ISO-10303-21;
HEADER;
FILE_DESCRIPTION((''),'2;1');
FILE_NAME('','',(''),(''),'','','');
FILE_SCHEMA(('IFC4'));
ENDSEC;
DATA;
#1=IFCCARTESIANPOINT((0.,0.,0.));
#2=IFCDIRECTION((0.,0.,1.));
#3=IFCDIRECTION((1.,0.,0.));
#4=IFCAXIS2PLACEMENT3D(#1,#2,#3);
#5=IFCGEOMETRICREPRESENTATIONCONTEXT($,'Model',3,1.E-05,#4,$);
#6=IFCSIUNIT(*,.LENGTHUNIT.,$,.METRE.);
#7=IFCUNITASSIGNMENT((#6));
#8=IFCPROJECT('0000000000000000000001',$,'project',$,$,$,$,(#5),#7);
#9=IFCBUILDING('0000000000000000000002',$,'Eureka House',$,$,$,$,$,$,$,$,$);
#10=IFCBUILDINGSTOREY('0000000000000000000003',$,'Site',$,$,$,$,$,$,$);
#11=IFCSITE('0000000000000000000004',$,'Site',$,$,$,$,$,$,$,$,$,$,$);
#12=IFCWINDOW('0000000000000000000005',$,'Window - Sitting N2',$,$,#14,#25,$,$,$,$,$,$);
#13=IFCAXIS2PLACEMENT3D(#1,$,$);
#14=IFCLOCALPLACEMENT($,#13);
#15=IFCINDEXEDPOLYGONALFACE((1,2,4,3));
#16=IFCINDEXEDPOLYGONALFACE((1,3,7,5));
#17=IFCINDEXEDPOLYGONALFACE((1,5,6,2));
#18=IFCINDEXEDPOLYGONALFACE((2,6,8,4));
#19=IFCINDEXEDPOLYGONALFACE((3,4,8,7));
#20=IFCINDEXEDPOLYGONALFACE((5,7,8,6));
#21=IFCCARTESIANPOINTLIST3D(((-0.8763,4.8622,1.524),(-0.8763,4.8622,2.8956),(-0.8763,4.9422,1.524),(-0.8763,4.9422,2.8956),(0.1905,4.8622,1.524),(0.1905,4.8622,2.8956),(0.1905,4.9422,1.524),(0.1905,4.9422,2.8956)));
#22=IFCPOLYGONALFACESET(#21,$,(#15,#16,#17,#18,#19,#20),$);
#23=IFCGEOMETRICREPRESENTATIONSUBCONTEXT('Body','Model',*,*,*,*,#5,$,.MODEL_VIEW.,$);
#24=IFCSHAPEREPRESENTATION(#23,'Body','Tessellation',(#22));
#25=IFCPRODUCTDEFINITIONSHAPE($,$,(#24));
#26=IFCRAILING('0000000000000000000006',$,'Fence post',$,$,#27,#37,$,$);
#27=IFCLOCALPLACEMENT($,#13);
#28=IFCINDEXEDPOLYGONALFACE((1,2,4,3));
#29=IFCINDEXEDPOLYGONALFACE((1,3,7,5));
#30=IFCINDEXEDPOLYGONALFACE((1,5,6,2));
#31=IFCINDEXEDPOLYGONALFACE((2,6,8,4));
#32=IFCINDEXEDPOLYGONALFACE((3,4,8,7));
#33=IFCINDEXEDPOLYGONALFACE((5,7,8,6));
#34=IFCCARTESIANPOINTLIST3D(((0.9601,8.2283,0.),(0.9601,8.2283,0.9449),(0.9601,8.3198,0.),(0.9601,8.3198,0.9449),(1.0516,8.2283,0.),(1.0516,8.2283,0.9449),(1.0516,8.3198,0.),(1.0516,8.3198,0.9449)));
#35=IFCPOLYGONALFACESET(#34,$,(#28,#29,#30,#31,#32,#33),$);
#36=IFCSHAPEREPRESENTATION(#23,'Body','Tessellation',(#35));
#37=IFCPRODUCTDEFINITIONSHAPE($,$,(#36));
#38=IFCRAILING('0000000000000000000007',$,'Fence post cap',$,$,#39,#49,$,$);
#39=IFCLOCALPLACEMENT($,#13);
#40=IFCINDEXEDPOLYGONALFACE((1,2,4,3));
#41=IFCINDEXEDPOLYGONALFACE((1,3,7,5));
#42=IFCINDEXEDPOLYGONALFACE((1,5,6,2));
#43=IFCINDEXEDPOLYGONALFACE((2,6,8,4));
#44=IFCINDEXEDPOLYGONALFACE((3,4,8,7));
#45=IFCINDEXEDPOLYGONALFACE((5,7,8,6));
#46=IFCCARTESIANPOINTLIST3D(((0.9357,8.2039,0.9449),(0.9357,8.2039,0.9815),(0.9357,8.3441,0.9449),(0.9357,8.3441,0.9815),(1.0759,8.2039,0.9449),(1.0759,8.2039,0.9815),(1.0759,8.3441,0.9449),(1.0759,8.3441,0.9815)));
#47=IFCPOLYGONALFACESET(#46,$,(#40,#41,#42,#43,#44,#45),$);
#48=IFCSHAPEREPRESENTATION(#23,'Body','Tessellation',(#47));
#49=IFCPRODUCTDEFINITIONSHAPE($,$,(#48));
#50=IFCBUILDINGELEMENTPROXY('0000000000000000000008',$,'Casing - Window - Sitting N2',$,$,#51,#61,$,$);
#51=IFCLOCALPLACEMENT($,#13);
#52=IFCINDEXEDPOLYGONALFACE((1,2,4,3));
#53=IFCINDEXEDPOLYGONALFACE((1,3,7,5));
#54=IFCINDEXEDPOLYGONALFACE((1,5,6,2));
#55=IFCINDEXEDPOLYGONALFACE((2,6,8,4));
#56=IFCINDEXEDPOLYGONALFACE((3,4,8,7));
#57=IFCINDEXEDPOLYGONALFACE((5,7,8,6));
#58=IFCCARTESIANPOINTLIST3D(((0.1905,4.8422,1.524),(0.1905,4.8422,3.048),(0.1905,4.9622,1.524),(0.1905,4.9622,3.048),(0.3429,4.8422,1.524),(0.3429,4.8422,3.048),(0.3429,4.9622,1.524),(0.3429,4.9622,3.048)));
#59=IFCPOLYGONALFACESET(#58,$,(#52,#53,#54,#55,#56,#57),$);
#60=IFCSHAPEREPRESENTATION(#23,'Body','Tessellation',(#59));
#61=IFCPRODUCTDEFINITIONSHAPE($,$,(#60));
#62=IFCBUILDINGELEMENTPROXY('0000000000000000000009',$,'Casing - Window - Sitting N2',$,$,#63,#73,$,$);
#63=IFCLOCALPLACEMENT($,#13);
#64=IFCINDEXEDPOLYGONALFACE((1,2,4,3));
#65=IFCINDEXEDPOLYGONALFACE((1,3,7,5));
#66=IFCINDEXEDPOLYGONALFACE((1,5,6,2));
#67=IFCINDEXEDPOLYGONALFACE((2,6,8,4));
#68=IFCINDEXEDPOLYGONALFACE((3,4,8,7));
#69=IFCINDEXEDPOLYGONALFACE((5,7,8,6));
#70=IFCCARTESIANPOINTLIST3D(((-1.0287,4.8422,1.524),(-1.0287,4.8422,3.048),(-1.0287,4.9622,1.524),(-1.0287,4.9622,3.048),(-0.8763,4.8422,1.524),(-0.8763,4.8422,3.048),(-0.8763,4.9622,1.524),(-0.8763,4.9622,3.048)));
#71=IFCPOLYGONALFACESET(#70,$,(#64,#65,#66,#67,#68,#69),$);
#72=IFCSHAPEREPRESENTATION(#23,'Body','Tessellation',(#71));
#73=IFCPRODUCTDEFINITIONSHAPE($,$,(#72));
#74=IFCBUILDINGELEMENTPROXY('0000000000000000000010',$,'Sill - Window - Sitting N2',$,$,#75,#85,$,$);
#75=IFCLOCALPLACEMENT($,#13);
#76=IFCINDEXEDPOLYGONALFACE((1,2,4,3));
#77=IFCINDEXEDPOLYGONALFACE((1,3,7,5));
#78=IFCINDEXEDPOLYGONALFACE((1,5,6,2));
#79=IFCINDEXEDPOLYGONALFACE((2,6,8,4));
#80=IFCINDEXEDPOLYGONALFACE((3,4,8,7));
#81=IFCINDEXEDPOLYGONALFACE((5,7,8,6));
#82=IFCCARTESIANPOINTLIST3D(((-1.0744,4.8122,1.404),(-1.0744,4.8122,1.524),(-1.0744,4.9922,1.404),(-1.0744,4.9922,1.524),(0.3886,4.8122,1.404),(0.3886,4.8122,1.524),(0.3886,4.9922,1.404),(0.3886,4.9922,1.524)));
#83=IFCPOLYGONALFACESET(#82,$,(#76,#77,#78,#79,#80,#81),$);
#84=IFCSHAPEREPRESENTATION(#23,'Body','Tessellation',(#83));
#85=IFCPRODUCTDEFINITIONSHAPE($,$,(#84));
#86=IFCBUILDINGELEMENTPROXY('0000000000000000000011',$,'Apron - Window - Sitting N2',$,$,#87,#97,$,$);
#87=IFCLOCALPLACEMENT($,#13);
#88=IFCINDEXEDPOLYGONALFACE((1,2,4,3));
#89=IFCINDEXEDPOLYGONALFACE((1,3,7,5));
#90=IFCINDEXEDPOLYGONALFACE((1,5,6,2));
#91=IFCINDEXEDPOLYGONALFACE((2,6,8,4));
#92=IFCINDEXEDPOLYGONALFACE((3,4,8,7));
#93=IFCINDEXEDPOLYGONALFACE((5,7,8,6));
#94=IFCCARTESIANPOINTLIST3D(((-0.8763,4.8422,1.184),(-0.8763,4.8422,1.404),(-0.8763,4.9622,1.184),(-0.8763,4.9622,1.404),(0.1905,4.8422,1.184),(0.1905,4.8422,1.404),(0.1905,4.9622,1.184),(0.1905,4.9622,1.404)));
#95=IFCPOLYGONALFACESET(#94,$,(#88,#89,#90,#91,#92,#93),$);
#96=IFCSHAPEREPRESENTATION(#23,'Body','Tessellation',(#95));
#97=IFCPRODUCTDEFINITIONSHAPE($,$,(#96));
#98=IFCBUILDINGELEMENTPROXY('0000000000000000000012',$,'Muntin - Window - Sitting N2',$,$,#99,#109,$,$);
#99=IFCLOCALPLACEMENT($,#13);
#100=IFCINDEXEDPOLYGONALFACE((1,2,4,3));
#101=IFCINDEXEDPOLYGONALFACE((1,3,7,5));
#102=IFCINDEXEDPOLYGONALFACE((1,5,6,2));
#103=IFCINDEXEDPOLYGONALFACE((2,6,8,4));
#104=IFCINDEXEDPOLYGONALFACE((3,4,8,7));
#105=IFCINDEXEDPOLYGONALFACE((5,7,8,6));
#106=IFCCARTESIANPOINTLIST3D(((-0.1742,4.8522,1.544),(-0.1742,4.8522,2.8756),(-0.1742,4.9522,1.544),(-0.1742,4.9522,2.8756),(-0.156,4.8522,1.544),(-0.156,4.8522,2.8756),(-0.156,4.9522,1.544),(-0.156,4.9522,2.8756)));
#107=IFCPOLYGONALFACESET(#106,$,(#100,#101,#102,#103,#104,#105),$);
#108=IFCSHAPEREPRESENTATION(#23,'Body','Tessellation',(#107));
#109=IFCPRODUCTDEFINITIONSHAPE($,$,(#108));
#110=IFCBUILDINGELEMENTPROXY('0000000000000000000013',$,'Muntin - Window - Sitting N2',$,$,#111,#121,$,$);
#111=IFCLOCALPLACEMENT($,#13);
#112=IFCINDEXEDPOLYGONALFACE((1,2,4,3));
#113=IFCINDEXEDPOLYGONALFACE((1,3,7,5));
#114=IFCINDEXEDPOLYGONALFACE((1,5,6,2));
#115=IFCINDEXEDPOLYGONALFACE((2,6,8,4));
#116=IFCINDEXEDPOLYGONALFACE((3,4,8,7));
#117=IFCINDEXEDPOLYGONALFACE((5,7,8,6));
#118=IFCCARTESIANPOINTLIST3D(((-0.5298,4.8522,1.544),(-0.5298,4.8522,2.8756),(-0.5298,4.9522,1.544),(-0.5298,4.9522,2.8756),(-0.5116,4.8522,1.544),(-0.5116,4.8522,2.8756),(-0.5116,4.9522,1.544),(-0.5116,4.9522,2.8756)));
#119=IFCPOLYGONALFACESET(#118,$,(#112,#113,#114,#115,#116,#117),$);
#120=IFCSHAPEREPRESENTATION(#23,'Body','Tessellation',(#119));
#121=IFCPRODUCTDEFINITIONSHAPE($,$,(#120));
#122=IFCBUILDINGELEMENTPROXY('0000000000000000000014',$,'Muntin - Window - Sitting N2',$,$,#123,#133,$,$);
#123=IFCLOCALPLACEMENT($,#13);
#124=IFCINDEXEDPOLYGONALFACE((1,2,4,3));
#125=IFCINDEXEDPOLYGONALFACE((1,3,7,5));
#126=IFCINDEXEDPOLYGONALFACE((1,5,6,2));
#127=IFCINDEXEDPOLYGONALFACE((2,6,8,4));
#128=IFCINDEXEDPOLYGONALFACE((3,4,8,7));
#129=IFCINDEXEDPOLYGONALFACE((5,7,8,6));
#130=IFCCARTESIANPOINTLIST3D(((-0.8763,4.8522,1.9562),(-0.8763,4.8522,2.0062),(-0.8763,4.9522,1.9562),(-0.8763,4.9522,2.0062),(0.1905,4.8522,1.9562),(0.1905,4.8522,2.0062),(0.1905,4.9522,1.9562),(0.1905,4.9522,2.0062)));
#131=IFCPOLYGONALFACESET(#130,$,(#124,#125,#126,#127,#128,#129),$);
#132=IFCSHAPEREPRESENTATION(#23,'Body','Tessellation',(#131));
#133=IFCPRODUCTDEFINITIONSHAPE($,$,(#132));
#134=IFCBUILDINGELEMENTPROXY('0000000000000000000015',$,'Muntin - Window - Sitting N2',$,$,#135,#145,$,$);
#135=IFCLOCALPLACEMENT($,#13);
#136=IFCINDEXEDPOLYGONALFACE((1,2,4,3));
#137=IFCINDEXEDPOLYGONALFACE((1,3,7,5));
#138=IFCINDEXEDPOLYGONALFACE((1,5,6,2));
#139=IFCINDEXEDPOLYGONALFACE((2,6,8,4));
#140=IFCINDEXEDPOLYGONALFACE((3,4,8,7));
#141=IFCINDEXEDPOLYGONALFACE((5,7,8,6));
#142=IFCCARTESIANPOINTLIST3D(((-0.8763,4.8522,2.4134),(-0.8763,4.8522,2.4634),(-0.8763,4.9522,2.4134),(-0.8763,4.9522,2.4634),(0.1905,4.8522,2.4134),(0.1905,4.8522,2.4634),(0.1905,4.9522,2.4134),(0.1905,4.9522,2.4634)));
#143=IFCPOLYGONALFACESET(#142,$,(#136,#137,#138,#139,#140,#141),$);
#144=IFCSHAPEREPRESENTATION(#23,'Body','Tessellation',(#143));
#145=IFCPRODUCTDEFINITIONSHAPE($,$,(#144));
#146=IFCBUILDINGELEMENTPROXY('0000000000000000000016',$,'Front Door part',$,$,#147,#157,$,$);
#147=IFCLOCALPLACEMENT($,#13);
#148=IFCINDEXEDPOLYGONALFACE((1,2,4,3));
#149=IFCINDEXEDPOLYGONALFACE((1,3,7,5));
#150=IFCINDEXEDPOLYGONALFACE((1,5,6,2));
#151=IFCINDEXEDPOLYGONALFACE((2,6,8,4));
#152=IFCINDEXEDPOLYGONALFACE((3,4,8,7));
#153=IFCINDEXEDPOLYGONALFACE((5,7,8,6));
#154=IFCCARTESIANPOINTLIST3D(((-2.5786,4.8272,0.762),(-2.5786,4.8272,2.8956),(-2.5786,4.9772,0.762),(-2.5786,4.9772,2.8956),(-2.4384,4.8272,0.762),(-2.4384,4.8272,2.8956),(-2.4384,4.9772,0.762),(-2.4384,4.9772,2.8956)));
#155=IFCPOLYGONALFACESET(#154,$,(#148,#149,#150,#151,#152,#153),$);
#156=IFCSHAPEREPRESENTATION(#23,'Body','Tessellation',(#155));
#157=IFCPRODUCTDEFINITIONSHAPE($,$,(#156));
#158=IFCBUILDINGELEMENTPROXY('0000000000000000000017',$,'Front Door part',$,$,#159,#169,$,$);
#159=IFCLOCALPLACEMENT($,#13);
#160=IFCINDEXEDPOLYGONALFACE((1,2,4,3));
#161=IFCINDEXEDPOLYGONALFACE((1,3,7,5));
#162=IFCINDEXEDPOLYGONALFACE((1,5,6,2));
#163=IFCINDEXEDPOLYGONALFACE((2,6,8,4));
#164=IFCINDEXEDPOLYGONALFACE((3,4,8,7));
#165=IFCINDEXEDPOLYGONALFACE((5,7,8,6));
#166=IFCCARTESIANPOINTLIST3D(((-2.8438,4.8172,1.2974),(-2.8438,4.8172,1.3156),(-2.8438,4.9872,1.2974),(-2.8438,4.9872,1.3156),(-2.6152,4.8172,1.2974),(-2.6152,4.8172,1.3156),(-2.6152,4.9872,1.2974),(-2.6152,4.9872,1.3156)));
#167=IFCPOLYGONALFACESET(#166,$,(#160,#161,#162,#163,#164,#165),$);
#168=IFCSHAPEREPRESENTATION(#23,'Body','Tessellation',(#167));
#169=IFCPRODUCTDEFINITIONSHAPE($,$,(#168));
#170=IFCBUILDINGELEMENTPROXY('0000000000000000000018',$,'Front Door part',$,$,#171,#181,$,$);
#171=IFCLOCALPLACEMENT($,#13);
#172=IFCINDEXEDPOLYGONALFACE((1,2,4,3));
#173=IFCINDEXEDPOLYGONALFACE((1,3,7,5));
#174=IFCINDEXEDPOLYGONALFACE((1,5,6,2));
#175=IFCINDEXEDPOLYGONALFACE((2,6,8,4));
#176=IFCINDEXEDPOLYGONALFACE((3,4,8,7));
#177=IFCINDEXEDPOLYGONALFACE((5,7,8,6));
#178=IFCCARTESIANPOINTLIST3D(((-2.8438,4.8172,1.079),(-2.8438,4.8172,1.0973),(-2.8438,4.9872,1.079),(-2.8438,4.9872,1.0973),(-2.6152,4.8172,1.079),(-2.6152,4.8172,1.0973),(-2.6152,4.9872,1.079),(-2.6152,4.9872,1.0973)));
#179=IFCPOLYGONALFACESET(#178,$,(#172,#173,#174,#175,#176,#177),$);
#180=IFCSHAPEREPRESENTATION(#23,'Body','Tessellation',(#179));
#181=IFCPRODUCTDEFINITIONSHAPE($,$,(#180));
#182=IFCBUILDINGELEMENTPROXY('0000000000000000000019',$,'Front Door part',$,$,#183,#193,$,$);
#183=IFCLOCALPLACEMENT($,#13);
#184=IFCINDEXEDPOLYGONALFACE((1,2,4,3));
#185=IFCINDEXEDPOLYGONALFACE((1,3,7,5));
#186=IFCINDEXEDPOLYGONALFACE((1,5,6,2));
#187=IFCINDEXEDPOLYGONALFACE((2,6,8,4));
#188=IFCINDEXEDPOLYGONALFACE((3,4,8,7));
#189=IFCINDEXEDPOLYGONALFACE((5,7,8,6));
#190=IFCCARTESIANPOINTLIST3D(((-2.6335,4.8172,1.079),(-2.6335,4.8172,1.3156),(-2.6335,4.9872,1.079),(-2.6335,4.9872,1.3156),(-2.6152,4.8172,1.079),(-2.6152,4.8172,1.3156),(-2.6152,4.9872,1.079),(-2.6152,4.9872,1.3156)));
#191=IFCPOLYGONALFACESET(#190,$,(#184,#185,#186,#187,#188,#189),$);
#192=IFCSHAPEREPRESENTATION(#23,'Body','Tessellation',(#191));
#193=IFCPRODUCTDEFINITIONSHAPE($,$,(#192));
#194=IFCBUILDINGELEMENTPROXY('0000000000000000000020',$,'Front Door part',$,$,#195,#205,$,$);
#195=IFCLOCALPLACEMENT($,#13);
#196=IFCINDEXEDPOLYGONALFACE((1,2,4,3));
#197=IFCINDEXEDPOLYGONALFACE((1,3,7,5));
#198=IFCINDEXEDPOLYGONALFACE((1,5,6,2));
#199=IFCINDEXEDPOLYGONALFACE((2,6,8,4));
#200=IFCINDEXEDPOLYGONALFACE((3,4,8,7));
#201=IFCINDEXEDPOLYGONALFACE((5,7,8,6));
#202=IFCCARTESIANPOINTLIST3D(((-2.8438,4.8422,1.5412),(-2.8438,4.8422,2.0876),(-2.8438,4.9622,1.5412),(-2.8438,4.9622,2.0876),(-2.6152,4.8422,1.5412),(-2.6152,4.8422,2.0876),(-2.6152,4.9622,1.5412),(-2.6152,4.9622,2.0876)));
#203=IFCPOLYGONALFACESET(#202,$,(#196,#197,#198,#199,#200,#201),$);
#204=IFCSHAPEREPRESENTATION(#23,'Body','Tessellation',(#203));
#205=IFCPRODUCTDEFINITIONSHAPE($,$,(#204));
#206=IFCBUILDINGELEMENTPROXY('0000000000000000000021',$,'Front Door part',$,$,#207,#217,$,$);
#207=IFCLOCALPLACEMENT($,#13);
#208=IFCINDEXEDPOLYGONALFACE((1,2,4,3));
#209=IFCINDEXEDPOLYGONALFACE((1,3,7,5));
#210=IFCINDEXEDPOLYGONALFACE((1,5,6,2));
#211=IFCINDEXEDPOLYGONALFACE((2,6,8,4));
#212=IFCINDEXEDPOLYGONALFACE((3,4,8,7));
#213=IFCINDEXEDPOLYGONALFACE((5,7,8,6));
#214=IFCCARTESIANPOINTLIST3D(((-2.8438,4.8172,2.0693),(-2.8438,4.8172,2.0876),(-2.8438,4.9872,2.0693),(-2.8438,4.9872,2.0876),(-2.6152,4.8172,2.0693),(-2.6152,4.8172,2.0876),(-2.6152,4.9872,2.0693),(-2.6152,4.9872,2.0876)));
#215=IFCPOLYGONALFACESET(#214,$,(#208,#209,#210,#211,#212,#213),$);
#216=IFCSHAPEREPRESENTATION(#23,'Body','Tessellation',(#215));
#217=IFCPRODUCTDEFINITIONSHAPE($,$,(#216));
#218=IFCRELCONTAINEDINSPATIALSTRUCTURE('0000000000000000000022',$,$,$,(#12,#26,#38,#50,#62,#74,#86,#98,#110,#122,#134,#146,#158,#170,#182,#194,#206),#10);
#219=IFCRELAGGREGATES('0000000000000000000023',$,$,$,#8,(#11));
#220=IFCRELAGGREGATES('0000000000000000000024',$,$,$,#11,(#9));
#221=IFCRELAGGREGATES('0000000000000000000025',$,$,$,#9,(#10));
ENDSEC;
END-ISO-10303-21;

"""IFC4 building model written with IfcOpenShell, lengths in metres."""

from ifc_helpers import new_model, si_unit, frame, origin, origin_with_axes, origin_2d, place, context, subcontext, project, spatial, rectangle, extrude, element, save


model = new_model("IFC4")

# Units and contexts
model_context = context("Model", 3, precision=1e-05, world=origin_with_axes())
body_context = subcontext(model_context, "Body", "Model", "MODEL_VIEW")
ifc_project = project(units=[si_unit("LENGTHUNIT", "METRE")], contexts=[model_context])

# Site, building, storey
site = spatial("IfcSite", under=ifc_project, Name="Site")
building = spatial("IfcBuilding", under=site, Name="Eureka House")
storey = spatial("IfcBuildingStorey", under=building, Name="Site")

# Window
window_placement = place(None, frame((-0.3429, 4.9022, 1.524), z_axis=(0.0, 0.0, 1.0), x_axis=(1.0, 0.0, 0.0)))
element("IfcWindow", 1, at=window_placement, inside=storey, Name="Window - Sitting N2", context=body_context, shape_type="SweptSolid", body=[
    extrude(rectangle(XDim=1.0668, YDim=0.08, at=origin_2d()), origin(), (0.0, 0.0, 1.0), 1.3716),
])

# Railings
railing_1_placement = place(None, frame((1.0058, 8.274, 0.0), z_axis=(0.0, 0.0, 1.0), x_axis=(1.0, 0.0, 0.0)))
element("IfcRailing", 2, at=railing_1_placement, inside=storey, Name="Fence post", context=body_context, shape_type="SweptSolid", body=[
    extrude(rectangle(XDim=0.0914, YDim=0.0914, at=origin_2d()), origin(), (0.0, 0.0, 1.0), 0.9449),
])
railing_2_placement = place(None, frame((1.0058, 8.274, 0.9449), z_axis=(0.0, 0.0, 1.0), x_axis=(1.0, 0.0, 0.0)))
element("IfcRailing", 3, at=railing_2_placement, inside=storey, Name="Fence post cap", context=body_context, shape_type="SweptSolid", body=[
    extrude(rectangle(XDim=0.1402, YDim=0.1402, at=origin_2d()), origin(), (0.0, 0.0, 1.0), 0.0366),
])

# Building element proxies
for number, where, z_axis, x_axis, name in (
    (4, (0.2667, 4.9022, 1.524), (0.0, 0.0, 1.0), (1.0, 0.0, 0.0), "Casing - Window - Sitting N2"),
    (5, (-0.9525, 4.9022, 1.524), (0.0, 0.0, 1.0), (1.0, 0.0, 0.0), "Casing - Window - Sitting N2"),
):
    element("IfcBuildingElementProxy", number, at=place(None, frame(where, z_axis=z_axis, x_axis=x_axis)), inside=storey, Name=name, context=body_context, shape_type="SweptSolid", body=[
        extrude(rectangle(XDim=0.1524, YDim=0.12, at=origin_2d()), origin(), (0.0, 0.0, 1.0), 1.524),
    ])
proxy_1_placement = place(None, frame((-0.3429, 4.9022, 1.404), z_axis=(0.0, 0.0, 1.0), x_axis=(1.0, 0.0, 0.0)))
element("IfcBuildingElementProxy", 6, at=proxy_1_placement, inside=storey, Name="Sill - Window - Sitting N2", context=body_context, shape_type="SweptSolid", body=[
    extrude(rectangle(XDim=1.463, YDim=0.18, at=origin_2d()), origin(), (0.0, 0.0, 1.0), 0.12),
])
proxy_2_placement = place(None, frame((-0.3429, 4.9022, 1.184), z_axis=(0.0, 0.0, 1.0), x_axis=(1.0, 0.0, 0.0)))
element("IfcBuildingElementProxy", 7, at=proxy_2_placement, inside=storey, Name="Apron - Window - Sitting N2", context=body_context, shape_type="SweptSolid", body=[
    extrude(rectangle(XDim=1.0668, YDim=0.12, at=origin_2d()), origin(), (0.0, 0.0, 1.0), 0.22),
])
for number, where, z_axis, x_axis, name in (
    (8, (-0.1651, 4.9022, 1.544), (0.0, 0.0, 1.0), (1.0, 0.0, 0.0), "Muntin - Window - Sitting N2"),
    (9, (-0.5207, 4.9022, 1.544), (0.0, 0.0, 1.0), (1.0, 0.0, 0.0), "Muntin - Window - Sitting N2"),
):
    element("IfcBuildingElementProxy", number, at=place(None, frame(where, z_axis=z_axis, x_axis=x_axis)), inside=storey, Name=name, context=body_context, shape_type="SweptSolid", body=[
        extrude(rectangle(XDim=0.0183, YDim=0.1, at=origin_2d()), origin(), (0.0, 0.0, 1.0), 1.3316),
    ])
proxy_3_placement = place(None, frame((-0.3429, 4.9022, 1.9562), z_axis=(0.0, 0.0, 1.0), x_axis=(1.0, 0.0, 0.0)))
element("IfcBuildingElementProxy", 10, at=proxy_3_placement, inside=storey, Name="Muntin - Window - Sitting N2", context=body_context, shape_type="SweptSolid", body=[
    extrude(rectangle(XDim=1.0668, YDim=0.1, at=origin_2d()), origin(), (0.0, 0.0, 1.0), 0.05),
])
proxy_4_placement = place(None, frame((-0.3429, 4.9022, 2.4134), z_axis=(0.0, 0.0, 1.0), x_axis=(1.0, 0.0, 0.0)))
element("IfcBuildingElementProxy", 11, at=proxy_4_placement, inside=storey, Name="Muntin - Window - Sitting N2", context=body_context, shape_type="SweptSolid", body=[
    extrude(rectangle(XDim=1.0668, YDim=0.1, at=origin_2d()), origin(), (0.0, 0.0, 1.0), 0.05),
])
proxy_5_placement = place(None, frame((-2.5085, 4.9022, 0.762), z_axis=(0.0, 0.0, 1.0), x_axis=(1.0, 0.0, 0.0)))
element("IfcBuildingElementProxy", 12, at=proxy_5_placement, inside=storey, Name="Front Door part", context=body_context, shape_type="SweptSolid", body=[
    extrude(rectangle(XDim=0.1402, YDim=0.15, at=origin_2d()), origin(), (0.0, 0.0, 1.0), 2.1336),
])
for number, where, z_axis, x_axis, name in (
    (13, (-2.7295, 4.9022, 1.2974), (0.0, 0.0, 1.0), (1.0, 0.0, 0.0), "Front Door part"),
    (14, (-2.7295, 4.9022, 1.079), (0.0, 0.0, 1.0), (1.0, 0.0, 0.0), "Front Door part"),
):
    element("IfcBuildingElementProxy", number, at=place(None, frame(where, z_axis=z_axis, x_axis=x_axis)), inside=storey, Name=name, context=body_context, shape_type="SweptSolid", body=[
        extrude(rectangle(XDim=0.2286, YDim=0.17, at=origin_2d()), origin(), (0.0, 0.0, 1.0), 0.0183),
    ])
proxy_6_placement = place(None, frame((-2.6243, 4.9022, 1.079), z_axis=(0.0, 0.0, 1.0), x_axis=(1.0, 0.0, 0.0)))
element("IfcBuildingElementProxy", 15, at=proxy_6_placement, inside=storey, Name="Front Door part", context=body_context, shape_type="SweptSolid", body=[
    extrude(rectangle(XDim=0.0183, YDim=0.17, at=origin_2d()), origin(), (0.0, 0.0, 1.0), 0.2366),
])
proxy_7_placement = place(None, frame((-2.7295, 4.9022, 1.5412), z_axis=(0.0, 0.0, 1.0), x_axis=(1.0, 0.0, 0.0)))
element("IfcBuildingElementProxy", 16, at=proxy_7_placement, inside=storey, Name="Front Door part", context=body_context, shape_type="SweptSolid", body=[
    extrude(rectangle(XDim=0.2286, YDim=0.12, at=origin_2d()), origin(), (0.0, 0.0, 1.0), 0.5464),
])
for number, where, z_axis, x_axis, name in (
    (17, (-2.7295, 4.9022, 2.0693), (0.0, 0.0, 1.0), (1.0, 0.0, 0.0), "Front Door part"),
):
    element("IfcBuildingElementProxy", number, at=place(None, frame(where, z_axis=z_axis, x_axis=x_axis)), inside=storey, Name=name, context=body_context, shape_type="SweptSolid", body=[
        extrude(rectangle(XDim=0.2286, YDim=0.17, at=origin_2d()), origin(), (0.0, 0.0, 1.0), 0.0183),
    ])

save(model, "model.ifc")
